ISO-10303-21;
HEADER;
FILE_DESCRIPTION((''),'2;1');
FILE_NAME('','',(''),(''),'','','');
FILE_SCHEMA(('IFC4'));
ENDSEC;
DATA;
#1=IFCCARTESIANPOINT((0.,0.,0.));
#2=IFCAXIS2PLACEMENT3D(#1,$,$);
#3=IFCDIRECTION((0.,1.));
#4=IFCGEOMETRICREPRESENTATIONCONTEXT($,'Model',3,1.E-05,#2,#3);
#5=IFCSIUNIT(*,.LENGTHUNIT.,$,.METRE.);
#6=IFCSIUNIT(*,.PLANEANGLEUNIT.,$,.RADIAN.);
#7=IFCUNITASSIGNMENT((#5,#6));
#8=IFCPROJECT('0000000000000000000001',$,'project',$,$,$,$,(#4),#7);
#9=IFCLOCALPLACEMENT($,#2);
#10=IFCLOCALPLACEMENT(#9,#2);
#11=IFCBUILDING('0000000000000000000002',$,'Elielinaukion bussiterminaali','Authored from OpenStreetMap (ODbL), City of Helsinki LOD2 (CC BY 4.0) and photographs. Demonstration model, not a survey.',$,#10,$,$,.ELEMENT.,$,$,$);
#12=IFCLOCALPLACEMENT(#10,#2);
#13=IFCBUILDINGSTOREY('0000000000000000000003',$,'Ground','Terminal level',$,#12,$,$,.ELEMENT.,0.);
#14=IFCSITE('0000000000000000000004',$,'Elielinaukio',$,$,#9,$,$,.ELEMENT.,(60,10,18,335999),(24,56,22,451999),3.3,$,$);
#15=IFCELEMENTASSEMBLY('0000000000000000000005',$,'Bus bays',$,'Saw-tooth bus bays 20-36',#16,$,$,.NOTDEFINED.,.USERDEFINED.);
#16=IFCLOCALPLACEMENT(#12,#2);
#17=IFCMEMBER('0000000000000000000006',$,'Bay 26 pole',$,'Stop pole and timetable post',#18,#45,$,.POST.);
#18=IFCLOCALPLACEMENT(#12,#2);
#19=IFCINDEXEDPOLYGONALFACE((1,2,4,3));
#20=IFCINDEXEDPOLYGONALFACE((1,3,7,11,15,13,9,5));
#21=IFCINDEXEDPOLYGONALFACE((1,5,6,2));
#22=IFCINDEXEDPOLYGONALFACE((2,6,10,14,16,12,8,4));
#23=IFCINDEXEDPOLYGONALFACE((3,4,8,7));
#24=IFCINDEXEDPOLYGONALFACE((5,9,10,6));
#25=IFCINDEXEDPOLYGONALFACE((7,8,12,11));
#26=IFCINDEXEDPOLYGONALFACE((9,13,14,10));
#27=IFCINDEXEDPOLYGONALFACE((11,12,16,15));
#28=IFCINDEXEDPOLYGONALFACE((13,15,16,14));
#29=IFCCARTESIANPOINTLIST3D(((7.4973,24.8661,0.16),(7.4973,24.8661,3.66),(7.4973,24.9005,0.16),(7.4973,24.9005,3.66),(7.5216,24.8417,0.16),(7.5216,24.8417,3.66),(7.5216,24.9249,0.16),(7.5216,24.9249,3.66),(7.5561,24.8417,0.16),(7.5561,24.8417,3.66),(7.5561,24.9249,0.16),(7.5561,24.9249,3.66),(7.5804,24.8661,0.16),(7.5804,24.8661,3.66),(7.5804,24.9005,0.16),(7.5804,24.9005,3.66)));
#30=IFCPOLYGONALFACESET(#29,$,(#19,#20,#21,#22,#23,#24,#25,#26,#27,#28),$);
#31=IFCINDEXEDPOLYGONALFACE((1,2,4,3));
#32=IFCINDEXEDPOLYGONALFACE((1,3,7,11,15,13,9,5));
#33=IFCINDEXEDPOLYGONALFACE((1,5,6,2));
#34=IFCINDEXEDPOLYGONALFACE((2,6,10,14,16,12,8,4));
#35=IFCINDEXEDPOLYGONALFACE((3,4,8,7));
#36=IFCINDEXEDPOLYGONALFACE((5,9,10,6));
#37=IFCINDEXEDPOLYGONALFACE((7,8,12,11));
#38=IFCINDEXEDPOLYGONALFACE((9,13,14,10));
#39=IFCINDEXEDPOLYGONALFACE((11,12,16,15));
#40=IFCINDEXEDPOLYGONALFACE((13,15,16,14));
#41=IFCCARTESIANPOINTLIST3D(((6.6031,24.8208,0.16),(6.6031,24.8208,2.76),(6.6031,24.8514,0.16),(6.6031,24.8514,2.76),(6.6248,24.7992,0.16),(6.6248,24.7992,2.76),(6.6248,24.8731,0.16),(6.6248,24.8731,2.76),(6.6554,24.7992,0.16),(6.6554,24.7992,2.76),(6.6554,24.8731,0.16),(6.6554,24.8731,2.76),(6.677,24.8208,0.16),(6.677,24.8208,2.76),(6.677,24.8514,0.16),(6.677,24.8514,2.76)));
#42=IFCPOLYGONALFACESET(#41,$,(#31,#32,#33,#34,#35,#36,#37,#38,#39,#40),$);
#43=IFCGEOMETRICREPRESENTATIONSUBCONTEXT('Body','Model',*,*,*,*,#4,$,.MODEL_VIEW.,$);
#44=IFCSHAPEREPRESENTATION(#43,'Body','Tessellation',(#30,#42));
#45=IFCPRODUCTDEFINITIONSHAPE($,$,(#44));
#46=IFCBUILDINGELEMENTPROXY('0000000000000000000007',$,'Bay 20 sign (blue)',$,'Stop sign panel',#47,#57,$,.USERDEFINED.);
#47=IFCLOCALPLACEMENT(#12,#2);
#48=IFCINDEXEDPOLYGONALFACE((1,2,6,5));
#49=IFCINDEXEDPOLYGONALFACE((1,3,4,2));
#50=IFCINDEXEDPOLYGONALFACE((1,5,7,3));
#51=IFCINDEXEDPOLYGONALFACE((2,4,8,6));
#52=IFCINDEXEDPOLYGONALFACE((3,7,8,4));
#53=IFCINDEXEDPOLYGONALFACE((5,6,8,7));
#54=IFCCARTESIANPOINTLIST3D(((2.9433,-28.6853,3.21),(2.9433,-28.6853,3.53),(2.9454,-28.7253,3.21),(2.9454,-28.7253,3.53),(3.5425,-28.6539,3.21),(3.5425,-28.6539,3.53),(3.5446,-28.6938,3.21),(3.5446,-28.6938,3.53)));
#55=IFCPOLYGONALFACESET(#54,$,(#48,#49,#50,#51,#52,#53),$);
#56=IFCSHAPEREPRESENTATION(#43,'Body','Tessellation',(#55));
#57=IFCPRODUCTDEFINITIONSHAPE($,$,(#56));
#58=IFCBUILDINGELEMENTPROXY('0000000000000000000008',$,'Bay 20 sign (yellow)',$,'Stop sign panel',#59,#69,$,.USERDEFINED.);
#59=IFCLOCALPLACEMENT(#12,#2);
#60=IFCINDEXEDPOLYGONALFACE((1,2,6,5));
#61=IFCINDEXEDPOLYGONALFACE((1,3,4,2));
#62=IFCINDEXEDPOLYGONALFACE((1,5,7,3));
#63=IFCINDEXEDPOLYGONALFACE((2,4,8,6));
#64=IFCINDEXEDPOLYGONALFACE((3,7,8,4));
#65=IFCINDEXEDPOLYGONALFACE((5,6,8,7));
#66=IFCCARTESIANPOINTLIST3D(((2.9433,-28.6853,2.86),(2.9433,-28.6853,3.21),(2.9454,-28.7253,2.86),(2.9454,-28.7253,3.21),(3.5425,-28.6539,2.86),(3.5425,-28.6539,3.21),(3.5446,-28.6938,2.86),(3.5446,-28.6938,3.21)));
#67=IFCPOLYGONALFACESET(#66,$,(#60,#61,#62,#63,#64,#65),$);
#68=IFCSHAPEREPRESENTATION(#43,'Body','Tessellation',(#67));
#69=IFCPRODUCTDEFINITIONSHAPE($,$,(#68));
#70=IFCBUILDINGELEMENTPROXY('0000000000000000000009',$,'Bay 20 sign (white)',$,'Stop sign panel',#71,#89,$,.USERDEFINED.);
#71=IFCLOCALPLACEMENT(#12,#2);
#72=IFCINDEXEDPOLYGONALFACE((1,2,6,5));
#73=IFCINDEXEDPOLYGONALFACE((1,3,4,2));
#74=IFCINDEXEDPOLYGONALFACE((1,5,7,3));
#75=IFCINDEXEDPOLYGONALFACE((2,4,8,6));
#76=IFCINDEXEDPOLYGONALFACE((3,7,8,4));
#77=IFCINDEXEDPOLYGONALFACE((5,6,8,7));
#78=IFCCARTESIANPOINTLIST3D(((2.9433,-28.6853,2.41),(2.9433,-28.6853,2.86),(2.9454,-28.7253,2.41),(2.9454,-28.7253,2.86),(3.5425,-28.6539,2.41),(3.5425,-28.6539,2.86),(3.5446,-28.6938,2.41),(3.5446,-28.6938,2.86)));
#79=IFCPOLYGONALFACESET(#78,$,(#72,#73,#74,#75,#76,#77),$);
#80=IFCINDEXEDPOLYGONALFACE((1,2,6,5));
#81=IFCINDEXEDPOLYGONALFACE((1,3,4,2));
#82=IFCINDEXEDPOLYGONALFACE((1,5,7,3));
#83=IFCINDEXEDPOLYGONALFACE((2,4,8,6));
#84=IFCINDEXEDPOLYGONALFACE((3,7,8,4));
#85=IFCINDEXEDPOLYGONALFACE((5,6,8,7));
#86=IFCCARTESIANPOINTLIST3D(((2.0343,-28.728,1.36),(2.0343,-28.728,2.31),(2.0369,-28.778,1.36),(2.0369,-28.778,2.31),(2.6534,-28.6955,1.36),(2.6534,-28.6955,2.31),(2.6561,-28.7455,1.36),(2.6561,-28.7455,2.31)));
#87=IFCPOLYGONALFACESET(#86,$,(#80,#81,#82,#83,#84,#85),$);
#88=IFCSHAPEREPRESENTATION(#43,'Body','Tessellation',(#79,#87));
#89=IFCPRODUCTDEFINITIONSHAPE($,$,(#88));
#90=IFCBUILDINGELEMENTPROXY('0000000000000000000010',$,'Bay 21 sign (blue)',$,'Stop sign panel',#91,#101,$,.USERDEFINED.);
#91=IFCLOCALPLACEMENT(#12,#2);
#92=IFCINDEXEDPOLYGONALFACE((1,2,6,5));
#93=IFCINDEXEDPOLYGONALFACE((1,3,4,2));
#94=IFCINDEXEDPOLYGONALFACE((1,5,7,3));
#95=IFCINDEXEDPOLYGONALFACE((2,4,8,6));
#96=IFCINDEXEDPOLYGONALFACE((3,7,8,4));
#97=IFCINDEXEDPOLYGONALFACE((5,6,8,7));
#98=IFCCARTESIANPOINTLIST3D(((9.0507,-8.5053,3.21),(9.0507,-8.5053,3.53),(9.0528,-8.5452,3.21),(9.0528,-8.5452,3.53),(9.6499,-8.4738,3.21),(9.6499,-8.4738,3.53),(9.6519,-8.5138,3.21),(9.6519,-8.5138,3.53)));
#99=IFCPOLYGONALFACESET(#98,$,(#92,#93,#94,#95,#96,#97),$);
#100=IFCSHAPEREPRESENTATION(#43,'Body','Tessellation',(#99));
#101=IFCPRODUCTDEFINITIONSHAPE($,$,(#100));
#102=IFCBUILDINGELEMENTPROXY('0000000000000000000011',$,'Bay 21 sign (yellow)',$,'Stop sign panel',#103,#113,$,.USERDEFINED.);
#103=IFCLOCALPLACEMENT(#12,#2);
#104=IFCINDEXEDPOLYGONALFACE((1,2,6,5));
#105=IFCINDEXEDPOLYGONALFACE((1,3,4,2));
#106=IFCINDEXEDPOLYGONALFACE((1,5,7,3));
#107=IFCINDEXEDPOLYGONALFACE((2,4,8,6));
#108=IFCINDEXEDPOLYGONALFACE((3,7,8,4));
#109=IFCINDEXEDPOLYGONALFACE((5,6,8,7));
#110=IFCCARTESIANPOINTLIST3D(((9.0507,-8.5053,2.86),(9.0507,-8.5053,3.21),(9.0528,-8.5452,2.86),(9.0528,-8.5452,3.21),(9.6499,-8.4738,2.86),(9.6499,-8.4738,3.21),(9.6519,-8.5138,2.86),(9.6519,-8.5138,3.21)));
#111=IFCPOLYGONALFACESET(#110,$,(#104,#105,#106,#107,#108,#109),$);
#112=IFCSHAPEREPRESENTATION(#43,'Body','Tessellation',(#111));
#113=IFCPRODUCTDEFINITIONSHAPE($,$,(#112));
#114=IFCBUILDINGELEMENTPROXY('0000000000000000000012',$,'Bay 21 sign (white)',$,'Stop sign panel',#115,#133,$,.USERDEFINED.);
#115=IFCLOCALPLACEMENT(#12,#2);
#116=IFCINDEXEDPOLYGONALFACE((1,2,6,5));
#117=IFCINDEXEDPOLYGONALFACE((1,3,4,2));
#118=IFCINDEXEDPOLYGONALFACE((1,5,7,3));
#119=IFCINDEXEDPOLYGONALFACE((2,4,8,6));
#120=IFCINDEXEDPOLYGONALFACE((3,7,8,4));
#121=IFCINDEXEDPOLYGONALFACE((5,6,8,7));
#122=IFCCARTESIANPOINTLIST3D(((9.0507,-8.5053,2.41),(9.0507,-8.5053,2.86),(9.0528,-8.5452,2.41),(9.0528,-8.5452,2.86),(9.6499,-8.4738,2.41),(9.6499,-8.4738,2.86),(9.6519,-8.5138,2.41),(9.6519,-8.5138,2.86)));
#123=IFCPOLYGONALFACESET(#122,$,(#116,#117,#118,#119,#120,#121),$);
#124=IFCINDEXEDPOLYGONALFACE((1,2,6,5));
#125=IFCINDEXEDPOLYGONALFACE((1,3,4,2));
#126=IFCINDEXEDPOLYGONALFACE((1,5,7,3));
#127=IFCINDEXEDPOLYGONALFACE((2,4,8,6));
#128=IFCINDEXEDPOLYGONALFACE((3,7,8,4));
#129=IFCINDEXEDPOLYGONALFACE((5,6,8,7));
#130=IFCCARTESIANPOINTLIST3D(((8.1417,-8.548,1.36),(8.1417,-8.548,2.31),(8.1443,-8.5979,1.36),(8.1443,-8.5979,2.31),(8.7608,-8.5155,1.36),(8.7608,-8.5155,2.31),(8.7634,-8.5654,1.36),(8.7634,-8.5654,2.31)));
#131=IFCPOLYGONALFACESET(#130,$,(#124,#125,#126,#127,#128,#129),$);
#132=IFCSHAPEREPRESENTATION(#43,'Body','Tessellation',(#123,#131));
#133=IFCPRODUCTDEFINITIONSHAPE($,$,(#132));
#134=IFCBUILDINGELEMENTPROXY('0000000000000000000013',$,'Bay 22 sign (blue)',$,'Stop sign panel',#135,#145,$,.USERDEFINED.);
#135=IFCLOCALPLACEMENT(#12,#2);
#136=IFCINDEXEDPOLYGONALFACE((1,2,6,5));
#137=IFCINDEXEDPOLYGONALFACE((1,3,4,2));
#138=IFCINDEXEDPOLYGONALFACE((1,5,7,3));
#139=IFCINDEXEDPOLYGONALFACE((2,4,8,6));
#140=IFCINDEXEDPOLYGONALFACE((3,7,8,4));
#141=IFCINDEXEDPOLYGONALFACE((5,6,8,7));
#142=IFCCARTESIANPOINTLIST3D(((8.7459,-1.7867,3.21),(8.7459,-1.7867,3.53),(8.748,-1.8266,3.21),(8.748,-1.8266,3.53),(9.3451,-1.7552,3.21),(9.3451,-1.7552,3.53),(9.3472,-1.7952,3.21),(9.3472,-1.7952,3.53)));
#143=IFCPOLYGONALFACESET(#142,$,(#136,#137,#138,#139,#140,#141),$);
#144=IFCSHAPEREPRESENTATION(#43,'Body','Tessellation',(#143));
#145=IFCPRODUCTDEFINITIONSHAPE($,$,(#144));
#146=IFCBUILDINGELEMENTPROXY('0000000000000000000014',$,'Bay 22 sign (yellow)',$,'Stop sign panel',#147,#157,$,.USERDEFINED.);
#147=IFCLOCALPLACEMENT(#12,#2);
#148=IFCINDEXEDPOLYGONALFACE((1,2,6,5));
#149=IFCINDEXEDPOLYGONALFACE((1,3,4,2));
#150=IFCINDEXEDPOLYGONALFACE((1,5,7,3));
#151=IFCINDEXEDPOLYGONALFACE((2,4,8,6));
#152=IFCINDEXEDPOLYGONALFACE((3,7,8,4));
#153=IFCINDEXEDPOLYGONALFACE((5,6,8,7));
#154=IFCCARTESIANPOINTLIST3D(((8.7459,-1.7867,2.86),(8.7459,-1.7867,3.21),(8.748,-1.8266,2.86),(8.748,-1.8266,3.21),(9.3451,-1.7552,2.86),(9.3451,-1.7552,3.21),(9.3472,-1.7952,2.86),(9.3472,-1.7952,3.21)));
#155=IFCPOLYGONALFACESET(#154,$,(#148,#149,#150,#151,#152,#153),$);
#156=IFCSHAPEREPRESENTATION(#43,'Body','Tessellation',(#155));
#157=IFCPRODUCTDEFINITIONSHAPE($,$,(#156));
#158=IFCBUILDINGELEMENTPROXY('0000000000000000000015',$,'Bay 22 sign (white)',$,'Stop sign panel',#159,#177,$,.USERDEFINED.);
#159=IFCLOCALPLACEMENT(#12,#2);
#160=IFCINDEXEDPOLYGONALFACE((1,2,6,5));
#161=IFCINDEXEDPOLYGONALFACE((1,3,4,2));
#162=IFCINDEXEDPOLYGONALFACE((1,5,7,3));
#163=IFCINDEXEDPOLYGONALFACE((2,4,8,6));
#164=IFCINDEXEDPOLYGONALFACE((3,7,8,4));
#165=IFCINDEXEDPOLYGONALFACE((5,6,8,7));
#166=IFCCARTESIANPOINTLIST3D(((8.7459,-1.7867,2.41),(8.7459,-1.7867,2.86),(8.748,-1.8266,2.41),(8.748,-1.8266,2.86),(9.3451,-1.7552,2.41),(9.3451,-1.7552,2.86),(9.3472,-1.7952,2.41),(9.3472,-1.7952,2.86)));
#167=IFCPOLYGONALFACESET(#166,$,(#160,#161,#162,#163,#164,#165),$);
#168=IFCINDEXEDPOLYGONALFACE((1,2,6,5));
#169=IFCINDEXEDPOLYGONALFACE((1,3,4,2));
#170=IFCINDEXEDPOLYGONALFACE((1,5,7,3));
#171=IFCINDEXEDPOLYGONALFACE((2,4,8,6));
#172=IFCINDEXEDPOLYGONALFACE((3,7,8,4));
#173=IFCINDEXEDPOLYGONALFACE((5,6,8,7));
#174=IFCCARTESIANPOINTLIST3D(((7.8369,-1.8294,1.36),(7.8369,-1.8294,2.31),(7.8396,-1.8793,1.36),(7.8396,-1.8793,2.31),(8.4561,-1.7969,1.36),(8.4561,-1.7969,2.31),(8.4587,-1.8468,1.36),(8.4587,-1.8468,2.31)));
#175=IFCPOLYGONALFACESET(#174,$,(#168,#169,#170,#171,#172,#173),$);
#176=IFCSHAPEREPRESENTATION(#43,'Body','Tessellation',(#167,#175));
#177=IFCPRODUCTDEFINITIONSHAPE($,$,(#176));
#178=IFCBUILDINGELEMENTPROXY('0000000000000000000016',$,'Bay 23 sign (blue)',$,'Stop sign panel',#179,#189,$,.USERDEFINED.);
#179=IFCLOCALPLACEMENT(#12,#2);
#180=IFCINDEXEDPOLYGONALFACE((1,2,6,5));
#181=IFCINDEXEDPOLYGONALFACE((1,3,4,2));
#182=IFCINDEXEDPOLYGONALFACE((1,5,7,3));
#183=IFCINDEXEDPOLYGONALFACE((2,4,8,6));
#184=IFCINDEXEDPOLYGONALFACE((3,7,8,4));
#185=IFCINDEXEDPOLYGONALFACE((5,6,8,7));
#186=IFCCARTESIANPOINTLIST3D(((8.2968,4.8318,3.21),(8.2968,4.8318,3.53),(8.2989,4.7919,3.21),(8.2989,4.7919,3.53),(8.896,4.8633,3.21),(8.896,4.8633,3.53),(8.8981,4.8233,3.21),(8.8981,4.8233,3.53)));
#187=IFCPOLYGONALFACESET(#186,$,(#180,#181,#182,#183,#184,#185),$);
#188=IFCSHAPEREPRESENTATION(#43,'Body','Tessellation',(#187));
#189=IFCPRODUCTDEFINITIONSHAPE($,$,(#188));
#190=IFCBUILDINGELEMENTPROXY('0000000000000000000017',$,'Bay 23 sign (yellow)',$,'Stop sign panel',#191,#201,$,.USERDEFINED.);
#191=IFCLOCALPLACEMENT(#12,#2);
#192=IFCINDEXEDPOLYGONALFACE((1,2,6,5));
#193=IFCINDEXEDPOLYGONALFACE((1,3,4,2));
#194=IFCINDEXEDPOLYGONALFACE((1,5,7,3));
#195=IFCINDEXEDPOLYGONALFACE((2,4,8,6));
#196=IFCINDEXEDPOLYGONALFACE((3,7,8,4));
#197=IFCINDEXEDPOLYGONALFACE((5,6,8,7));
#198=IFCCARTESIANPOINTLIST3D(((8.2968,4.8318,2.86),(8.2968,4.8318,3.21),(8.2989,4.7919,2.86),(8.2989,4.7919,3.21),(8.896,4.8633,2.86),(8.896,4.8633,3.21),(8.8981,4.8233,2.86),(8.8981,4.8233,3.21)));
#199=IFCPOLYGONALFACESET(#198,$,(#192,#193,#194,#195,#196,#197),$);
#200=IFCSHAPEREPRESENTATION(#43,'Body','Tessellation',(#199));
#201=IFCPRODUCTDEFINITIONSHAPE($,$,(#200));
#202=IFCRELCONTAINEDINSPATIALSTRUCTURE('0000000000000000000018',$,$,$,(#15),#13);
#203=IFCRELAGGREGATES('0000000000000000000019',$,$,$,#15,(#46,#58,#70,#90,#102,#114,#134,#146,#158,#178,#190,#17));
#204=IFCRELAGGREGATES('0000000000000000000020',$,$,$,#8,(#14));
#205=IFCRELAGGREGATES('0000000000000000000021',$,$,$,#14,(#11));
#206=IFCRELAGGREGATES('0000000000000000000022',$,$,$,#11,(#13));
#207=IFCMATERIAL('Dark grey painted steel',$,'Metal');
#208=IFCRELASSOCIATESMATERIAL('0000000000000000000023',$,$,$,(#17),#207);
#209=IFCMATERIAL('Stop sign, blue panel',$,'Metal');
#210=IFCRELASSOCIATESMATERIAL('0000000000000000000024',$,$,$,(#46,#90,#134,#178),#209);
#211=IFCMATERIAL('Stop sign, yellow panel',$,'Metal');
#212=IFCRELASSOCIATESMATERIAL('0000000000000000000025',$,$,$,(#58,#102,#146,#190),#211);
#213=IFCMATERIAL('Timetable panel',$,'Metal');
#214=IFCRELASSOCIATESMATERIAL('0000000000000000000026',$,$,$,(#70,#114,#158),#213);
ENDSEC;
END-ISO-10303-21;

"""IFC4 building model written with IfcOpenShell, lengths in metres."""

from ifc_helpers import new_model, si_unit, direction, frame, frame_2d, origin, place, context, subcontext, project, spatial, polyline, rectangle, outline, extrude, material, element, aggregate, save


model = new_model("IFC4")

# Units and contexts
model_context = context("Model", 3, precision=1e-05, world=origin(), true_north=direction((0.0, 1.0)))
body_context = subcontext(model_context, "Body", "Model", "MODEL_VIEW")
ifc_project = project(units=[si_unit("LENGTHUNIT", "METRE"), si_unit("PLANEANGLEUNIT", "RADIAN")], contexts=[model_context])

# Site, building, storey
site_placement = place(None, origin())
site = spatial("IfcSite", under=ifc_project, at=site_placement, Name="Elielinaukio", CompositionType="ELEMENT", RefLatitude=(60, 10, 18, 335999), RefLongitude=(24, 56, 22, 451999), RefElevation=3.3)
building_placement = place(site_placement, origin())
building = spatial("IfcBuilding", under=site, at=building_placement, Name="Elielinaukion bussiterminaali", Description="Authored from OpenStreetMap (ODbL), City of Helsinki LOD2 (CC BY 4.0) and photographs. Demonstration model, not a survey.", CompositionType="ELEMENT")
storey_placement = place(building_placement, origin())
storey = spatial("IfcBuildingStorey", under=building, at=storey_placement, Name="Ground", Description="Terminal level", CompositionType="ELEMENT", Elevation=0.0)

# Element assembly, member, building element proxies
assembly_placement = place(building_placement, origin())
assembly = element("IfcElementAssembly", 1, at=assembly_placement, inside=storey, Name="Bus bays", ObjectType="Saw-tooth bus bays 20-36", AssemblyPlace="NOTDEFINED", PredefinedType="USERDEFINED")
ifc_material_1 = material(Name="Dark grey painted steel", Category="Metal")
member_1_placement = place(building_placement, origin())
member_1 = element("IfcMember", 2, at=member_1_placement, material=ifc_material_1, Name="Bay 26 pole", ObjectType="Stop pole and timetable post", PredefinedType="POST", context=body_context, shape_type="SweptSolid", body=[
    extrude(outline(polyline([(7.5804, 24.9005), (7.5561, 24.9249), (7.5216, 24.9249), (7.4973, 24.9005), (7.4973, 24.8661), (7.5216, 24.8417), (7.5561, 24.8417), (7.5804, 24.8661), (7.5804, 24.9005)])), frame((0.0, 0.0, 0.16)), (0.0, 0.0, 1.0), 3.5),
    extrude(outline(polyline([(6.677, 24.8514), (6.6554, 24.8731), (6.6248, 24.8731), (6.6031, 24.8514), (6.6031, 24.8208), (6.6248, 24.7992), (6.6554, 24.7992), (6.677, 24.8208), (6.677, 24.8514)])), frame((0.0, 0.0, 0.16)), (0.0, 0.0, 1.0), 2.6),
])
ifc_material_2 = material(Name="Stop sign, blue panel", Category="Metal")
proxy_1_placement = place(building_placement, origin())
proxy_1 = element("IfcBuildingElementProxy", 3, at=proxy_1_placement, material=ifc_material_2, Name="Bay 20 sign (blue)", ObjectType="Stop sign panel", PredefinedType="USERDEFINED", context=body_context, shape_type="SweptSolid", body=[
    extrude(rectangle(XDim=0.04, YDim=0.6, at=frame_2d((0.0, 0.0), x_axis=(-0.052408, 0.998626))), frame((3.2439, -28.6896, 3.21)), (0.0, 0.0, 1.0), 0.32),
])
ifc_material_3 = material(Name="Stop sign, yellow panel", Category="Metal")
proxy_2_placement = place(building_placement, origin())
proxy_2 = element("IfcBuildingElementProxy", 4, at=proxy_2_placement, material=ifc_material_3, Name="Bay 20 sign (yellow)", ObjectType="Stop sign panel", PredefinedType="USERDEFINED", context=body_context, shape_type="SweptSolid", body=[
    extrude(rectangle(XDim=0.04, YDim=0.6, at=frame_2d((0.0, 0.0), x_axis=(-0.052408, 0.998626))), frame((3.2439, -28.6896, 2.86)), (0.0, 0.0, 1.0), 0.35),
])
ifc_material_4 = material(Name="Timetable panel", Category="Metal")
proxy_3_placement = place(building_placement, origin())
proxy_3 = element("IfcBuildingElementProxy", 5, at=proxy_3_placement, material=ifc_material_4, Name="Bay 20 sign (white)", ObjectType="Stop sign panel", PredefinedType="USERDEFINED", context=body_context, shape_type="SweptSolid", body=[
    extrude(rectangle(XDim=0.04, YDim=0.6, at=frame_2d((0.0, 0.0), x_axis=(-0.052408, 0.998626))), frame((3.2439, -28.6896, 2.41)), (0.0, 0.0, 1.0), 0.45),
    extrude(rectangle(XDim=0.05, YDim=0.62, at=frame_2d((0.0, 0.0), x_axis=(-0.052408, 0.998626))), frame((2.3452, -28.7367, 1.36)), (0.0, 0.0, 1.0), 0.95),
])
proxy_4_placement = place(building_placement, origin())
proxy_4 = element("IfcBuildingElementProxy", 6, at=proxy_4_placement, material=ifc_material_2, Name="Bay 21 sign (blue)", ObjectType="Stop sign panel", PredefinedType="USERDEFINED", context=body_context, shape_type="SweptSolid", body=[
    extrude(rectangle(XDim=0.04, YDim=0.6, at=frame_2d((0.0, 0.0), x_axis=(-0.052408, 0.998626))), frame((9.3513, -8.5095, 3.21)), (0.0, 0.0, 1.0), 0.32),
])
proxy_5_placement = place(building_placement, origin())
proxy_5 = element("IfcBuildingElementProxy", 7, at=proxy_5_placement, material=ifc_material_3, Name="Bay 21 sign (yellow)", ObjectType="Stop sign panel", PredefinedType="USERDEFINED", context=body_context, shape_type="SweptSolid", body=[
    extrude(rectangle(XDim=0.04, YDim=0.6, at=frame_2d((0.0, 0.0), x_axis=(-0.052408, 0.998626))), frame((9.3513, -8.5095, 2.86)), (0.0, 0.0, 1.0), 0.35),
])
proxy_6_placement = place(building_placement, origin())
proxy_6 = element("IfcBuildingElementProxy", 8, at=proxy_6_placement, material=ifc_material_4, Name="Bay 21 sign (white)", ObjectType="Stop sign panel", PredefinedType="USERDEFINED", context=body_context, shape_type="SweptSolid", body=[
    extrude(rectangle(XDim=0.04, YDim=0.6, at=frame_2d((0.0, 0.0), x_axis=(-0.052408, 0.998626))), frame((9.3513, -8.5095, 2.41)), (0.0, 0.0, 1.0), 0.45),
    extrude(rectangle(XDim=0.05, YDim=0.62, at=frame_2d((0.0, 0.0), x_axis=(-0.052408, 0.998626))), frame((8.4525, -8.5567, 1.36)), (0.0, 0.0, 1.0), 0.95),
])
proxy_7_placement = place(building_placement, origin())
proxy_7 = element("IfcBuildingElementProxy", 9, at=proxy_7_placement, material=ifc_material_2, Name="Bay 22 sign (blue)", ObjectType="Stop sign panel", PredefinedType="USERDEFINED", context=body_context, shape_type="SweptSolid", body=[
    extrude(rectangle(XDim=0.04, YDim=0.6, at=frame_2d((0.0, 0.0), x_axis=(-0.052408, 0.998626))), frame((9.0466, -1.7909, 3.21)), (0.0, 0.0, 1.0), 0.32),
])
proxy_8_placement = place(building_placement, origin())
proxy_8 = element("IfcBuildingElementProxy", 10, at=proxy_8_placement, material=ifc_material_3, Name="Bay 22 sign (yellow)", ObjectType="Stop sign panel", PredefinedType="USERDEFINED", context=body_context, shape_type="SweptSolid", body=[
    extrude(rectangle(XDim=0.04, YDim=0.6, at=frame_2d((0.0, 0.0), x_axis=(-0.052408, 0.998626))), frame((9.0466, -1.7909, 2.86)), (0.0, 0.0, 1.0), 0.35),
])
proxy_9_placement = place(building_placement, origin())
proxy_9 = element("IfcBuildingElementProxy", 11, at=proxy_9_placement, material=ifc_material_4, Name="Bay 22 sign (white)", ObjectType="Stop sign panel", PredefinedType="USERDEFINED", context=body_context, shape_type="SweptSolid", body=[
    extrude(rectangle(XDim=0.04, YDim=0.6, at=frame_2d((0.0, 0.0), x_axis=(-0.052408, 0.998626))), frame((9.0466, -1.7909, 2.41)), (0.0, 0.0, 1.0), 0.45),
    extrude(rectangle(XDim=0.05, YDim=0.62, at=frame_2d((0.0, 0.0), x_axis=(-0.052408, 0.998626))), frame((8.1478, -1.8381, 1.36)), (0.0, 0.0, 1.0), 0.95),
])
proxy_10_placement = place(building_placement, origin())
proxy_10 = element("IfcBuildingElementProxy", 12, at=proxy_10_placement, material=ifc_material_2, Name="Bay 23 sign (blue)", ObjectType="Stop sign panel", PredefinedType="USERDEFINED", context=body_context, shape_type="SweptSolid", body=[
    extrude(rectangle(XDim=0.04, YDim=0.6, at=frame_2d((0.0, 0.0), x_axis=(-0.052408, 0.998626))), frame((8.5974, 4.8276, 3.21)), (0.0, 0.0, 1.0), 0.32),
])
proxy_11_placement = place(building_placement, origin())
proxy_11 = element("IfcBuildingElementProxy", 13, at=proxy_11_placement, material=ifc_material_3, Name="Bay 23 sign (yellow)", ObjectType="Stop sign panel", PredefinedType="USERDEFINED", context=body_context, shape_type="SweptSolid", body=[
    extrude(rectangle(XDim=0.04, YDim=0.6, at=frame_2d((0.0, 0.0), x_axis=(-0.052408, 0.998626))), frame((8.5974, 4.8276, 2.86)), (0.0, 0.0, 1.0), 0.35),
])
aggregate(assembly, [proxy_1, proxy_2, proxy_3, proxy_4, proxy_5, proxy_6, proxy_7, proxy_8, proxy_9, proxy_10, proxy_11, member_1])

save(model, "model.ifc")
